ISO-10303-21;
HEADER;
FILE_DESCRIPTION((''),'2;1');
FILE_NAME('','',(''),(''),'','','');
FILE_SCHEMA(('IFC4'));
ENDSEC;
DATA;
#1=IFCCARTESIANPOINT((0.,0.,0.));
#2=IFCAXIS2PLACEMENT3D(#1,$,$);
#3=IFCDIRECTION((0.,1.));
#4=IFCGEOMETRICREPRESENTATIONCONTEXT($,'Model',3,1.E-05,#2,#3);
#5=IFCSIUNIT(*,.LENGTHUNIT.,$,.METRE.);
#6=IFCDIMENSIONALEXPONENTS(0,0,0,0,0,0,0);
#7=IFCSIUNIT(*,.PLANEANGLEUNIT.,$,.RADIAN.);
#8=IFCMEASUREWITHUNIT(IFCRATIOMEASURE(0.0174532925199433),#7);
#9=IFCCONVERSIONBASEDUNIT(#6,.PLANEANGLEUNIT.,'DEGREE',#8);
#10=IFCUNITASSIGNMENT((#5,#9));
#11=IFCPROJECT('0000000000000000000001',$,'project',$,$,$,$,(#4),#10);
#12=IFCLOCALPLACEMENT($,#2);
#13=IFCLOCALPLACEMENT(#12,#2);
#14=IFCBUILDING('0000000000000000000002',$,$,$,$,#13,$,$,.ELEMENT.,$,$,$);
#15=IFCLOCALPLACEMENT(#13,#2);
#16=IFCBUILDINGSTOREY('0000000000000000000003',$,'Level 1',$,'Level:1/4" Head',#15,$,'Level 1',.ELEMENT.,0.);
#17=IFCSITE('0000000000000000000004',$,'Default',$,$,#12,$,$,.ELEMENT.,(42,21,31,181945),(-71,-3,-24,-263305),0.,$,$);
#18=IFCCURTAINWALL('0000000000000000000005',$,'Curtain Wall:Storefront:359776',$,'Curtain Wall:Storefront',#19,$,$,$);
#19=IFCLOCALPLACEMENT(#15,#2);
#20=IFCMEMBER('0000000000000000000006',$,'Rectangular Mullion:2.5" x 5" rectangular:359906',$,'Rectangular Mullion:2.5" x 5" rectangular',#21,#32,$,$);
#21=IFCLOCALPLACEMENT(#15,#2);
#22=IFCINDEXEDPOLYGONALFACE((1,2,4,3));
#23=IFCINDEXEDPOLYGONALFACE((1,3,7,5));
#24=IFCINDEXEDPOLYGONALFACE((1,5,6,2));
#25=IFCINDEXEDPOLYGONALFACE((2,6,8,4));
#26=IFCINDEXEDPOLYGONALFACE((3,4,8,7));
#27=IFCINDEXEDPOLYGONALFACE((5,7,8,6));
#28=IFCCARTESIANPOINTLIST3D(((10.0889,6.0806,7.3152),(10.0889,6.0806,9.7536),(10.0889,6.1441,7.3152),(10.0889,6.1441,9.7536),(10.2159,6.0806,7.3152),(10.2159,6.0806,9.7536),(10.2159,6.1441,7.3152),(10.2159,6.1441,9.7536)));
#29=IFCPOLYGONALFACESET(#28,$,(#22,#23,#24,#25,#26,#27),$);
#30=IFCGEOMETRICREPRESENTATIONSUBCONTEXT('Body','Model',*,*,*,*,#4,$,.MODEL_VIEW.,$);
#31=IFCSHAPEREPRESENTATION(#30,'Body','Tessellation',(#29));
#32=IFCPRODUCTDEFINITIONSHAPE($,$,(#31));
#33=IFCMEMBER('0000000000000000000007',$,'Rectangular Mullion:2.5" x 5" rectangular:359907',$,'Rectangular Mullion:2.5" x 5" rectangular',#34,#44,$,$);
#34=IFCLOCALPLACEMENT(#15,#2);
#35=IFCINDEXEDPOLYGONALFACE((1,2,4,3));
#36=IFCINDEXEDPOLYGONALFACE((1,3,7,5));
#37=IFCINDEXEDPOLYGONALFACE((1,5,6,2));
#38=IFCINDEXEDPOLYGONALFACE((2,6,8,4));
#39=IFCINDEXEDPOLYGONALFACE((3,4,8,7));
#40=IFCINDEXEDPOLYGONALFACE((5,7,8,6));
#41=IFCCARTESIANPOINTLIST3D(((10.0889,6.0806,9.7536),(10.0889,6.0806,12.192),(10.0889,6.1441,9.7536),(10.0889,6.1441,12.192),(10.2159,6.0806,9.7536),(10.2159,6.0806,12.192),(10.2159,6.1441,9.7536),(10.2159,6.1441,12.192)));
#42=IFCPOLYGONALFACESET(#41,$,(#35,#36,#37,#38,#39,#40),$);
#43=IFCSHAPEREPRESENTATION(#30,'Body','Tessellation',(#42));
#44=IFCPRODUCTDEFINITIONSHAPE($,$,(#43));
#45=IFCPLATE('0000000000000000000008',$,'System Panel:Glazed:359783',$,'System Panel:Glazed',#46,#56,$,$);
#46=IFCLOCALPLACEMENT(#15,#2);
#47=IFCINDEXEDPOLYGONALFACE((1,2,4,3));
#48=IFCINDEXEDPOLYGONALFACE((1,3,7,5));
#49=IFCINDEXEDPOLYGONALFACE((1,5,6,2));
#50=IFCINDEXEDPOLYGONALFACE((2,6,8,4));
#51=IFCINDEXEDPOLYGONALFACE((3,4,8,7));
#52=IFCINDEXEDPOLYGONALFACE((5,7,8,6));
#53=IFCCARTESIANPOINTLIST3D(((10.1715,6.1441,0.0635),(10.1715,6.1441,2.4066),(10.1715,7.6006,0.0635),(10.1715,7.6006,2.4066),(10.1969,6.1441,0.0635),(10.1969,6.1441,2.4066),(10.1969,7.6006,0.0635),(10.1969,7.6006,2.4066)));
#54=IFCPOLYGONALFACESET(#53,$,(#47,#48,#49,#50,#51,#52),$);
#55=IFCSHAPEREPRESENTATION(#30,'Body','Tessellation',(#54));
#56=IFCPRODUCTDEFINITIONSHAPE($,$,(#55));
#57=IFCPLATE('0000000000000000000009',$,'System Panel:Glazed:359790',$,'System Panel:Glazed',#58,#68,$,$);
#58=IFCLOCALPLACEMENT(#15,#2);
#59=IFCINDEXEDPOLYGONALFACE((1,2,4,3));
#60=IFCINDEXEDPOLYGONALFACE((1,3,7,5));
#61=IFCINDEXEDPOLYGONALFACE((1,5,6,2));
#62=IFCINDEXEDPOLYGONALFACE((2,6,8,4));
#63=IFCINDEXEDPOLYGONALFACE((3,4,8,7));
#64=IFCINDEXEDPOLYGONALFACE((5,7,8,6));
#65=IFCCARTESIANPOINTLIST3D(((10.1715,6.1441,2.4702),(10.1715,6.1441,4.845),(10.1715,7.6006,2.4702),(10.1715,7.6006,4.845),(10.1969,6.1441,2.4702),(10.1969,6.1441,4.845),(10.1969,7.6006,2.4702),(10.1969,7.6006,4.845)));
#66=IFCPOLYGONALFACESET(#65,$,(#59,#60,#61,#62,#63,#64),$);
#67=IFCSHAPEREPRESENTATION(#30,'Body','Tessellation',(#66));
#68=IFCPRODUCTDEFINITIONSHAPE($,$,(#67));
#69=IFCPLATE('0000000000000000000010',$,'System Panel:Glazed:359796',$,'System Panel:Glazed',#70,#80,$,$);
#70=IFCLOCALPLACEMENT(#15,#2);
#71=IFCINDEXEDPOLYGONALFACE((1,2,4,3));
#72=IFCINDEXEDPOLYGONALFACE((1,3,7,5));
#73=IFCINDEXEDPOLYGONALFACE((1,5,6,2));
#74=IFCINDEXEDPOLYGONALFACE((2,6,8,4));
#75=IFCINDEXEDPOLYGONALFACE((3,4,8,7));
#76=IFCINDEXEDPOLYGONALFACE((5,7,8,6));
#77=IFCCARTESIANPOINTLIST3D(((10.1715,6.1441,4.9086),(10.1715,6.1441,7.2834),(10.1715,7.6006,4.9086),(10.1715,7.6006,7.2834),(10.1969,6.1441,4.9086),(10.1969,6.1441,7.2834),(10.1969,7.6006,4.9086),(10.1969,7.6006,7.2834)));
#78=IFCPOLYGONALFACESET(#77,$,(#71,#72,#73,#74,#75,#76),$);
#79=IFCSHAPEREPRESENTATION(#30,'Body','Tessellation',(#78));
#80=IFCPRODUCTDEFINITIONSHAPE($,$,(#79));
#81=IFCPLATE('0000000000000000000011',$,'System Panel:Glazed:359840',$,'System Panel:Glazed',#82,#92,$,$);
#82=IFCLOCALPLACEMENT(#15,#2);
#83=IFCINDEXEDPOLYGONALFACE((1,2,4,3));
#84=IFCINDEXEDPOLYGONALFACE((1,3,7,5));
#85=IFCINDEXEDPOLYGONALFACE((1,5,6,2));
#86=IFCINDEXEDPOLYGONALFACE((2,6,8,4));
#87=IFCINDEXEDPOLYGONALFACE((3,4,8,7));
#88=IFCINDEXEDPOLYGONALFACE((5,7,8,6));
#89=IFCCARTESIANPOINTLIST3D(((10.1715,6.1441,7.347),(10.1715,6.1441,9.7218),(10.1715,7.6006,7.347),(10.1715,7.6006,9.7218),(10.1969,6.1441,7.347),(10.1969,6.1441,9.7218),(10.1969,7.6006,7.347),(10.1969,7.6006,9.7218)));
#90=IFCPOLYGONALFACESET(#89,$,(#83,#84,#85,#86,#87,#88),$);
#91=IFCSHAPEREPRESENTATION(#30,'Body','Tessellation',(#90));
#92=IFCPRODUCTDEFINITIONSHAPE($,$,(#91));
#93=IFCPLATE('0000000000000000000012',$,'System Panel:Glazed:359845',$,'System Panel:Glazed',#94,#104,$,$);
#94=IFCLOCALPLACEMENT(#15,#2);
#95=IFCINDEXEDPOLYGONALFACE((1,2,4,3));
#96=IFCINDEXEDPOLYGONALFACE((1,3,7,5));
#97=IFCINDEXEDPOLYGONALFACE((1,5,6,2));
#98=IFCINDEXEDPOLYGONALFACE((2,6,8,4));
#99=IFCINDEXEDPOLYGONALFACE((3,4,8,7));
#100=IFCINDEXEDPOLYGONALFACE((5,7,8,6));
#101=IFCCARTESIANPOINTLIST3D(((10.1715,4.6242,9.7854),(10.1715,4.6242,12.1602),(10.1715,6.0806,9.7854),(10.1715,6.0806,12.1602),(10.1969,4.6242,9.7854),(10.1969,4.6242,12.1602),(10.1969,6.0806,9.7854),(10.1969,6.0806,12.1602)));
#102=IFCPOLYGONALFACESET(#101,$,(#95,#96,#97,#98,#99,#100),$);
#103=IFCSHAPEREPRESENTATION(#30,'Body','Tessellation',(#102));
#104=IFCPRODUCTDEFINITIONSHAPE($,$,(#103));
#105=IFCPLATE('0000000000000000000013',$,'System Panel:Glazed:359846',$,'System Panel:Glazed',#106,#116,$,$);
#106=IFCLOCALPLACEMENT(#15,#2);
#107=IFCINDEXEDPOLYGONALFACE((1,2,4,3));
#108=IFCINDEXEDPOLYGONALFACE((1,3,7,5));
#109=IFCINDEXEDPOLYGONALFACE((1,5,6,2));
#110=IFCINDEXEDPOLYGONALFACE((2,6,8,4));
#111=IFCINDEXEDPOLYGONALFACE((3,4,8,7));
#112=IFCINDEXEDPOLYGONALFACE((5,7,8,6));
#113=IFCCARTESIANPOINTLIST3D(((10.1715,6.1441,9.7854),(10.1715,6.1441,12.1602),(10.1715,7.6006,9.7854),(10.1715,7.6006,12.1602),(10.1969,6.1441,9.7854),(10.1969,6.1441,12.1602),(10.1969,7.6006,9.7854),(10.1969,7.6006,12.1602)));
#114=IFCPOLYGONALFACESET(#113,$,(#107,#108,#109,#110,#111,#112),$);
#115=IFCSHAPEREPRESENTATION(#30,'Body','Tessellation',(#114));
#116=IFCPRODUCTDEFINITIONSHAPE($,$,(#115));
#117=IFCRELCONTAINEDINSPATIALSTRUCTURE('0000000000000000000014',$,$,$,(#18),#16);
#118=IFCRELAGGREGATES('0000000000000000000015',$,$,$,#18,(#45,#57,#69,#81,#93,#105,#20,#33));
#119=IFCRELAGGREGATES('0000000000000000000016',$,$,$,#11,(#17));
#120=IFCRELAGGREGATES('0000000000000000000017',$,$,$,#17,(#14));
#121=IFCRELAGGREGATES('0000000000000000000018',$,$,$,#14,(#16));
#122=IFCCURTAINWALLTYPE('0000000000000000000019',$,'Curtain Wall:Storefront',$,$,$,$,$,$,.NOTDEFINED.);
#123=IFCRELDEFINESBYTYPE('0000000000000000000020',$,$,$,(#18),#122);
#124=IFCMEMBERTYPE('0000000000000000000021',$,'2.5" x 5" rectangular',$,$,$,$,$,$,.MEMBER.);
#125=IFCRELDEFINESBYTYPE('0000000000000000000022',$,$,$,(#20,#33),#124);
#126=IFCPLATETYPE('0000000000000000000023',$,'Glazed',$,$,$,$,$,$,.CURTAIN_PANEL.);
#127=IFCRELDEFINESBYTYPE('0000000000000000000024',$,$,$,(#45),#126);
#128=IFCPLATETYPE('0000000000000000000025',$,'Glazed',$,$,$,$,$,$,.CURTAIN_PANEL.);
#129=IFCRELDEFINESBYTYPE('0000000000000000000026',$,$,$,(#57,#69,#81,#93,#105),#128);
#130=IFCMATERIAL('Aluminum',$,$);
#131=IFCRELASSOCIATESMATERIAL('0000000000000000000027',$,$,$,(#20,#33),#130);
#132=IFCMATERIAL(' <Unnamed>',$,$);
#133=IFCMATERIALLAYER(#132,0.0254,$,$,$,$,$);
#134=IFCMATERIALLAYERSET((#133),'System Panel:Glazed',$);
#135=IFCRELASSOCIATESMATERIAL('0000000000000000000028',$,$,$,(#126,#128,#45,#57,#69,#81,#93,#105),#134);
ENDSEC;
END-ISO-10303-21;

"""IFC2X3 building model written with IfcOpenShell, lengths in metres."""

from ifc_helpers import new_model, entity, si_unit, converted_unit, direction, frame, origin, origin_2d_with_axis, place, context, subcontext, project, spatial, rectangle, extrude, source, transform, mapped, material, layer, layer_set, layer_usage, type_object, type_shapes, element, aggregate, save


model = new_model("IFC2X3")

# Units and contexts
model_context = context("Model", 3, precision=1e-05, world=origin(), true_north=direction((0.0, 1.0)))
body_context = subcontext(model_context, "Body", "Model", "MODEL_VIEW")
ifc_project = project(units=[si_unit("LENGTHUNIT", "METRE"), converted_unit("PLANEANGLEUNIT", "DEGREE", entity("IfcRatioMeasure", 0.0174532925199433), si_unit("PLANEANGLEUNIT", "RADIAN"), dimensions=[0, 0, 0, 0, 0, 0, 0])], contexts=[model_context])

# Site, building, storey
site_placement = place(None, origin())
site = spatial("IfcSite", under=ifc_project, at=site_placement, Name="Default", CompositionType="ELEMENT", RefLatitude=(42, 21, 31, 181945), RefLongitude=(-71, -3, -24, -263305), RefElevation=0.0)
building_placement = place(site_placement, origin())
building = spatial("IfcBuilding", under=site, at=building_placement, CompositionType="ELEMENT")
storey_placement = place(building_placement, origin())
storey = spatial("IfcBuildingStorey", under=building, at=storey_placement, Name="Level 1", ObjectType="Level:1/4\" Head", LongName="Level 1", CompositionType="ELEMENT", Elevation=0.0)

# Shared definitions
curtain_wall_type = type_object("IfcCurtainWallType", Name="Curtain Wall:Storefront", PredefinedType="NOTDEFINED")
ifc_material_1 = material(Name="Aluminum")

# Curtain wall, members, plates
curtain_wall_1_placement = place(storey_placement, origin())
curtain_wall_1 = element("IfcCurtainWall", 1, at=curtain_wall_1_placement, inside=storey, type_object=curtain_wall_type, Name="Curtain Wall:Storefront:359776", ObjectType="Curtain Wall:Storefront")
member_type_1 = type_object("IfcMemberType", Name="2.5\" x 5\" rectangular", PredefinedType="MEMBER")
shared_shape_1 = source(origin(), body_context, "Body", "SweptSolid", [
    extrude(rectangle(XDim=0.127, YDim=0.0635, at=origin_2d_with_axis()), frame((0.0, 0.0, -2.4384), z_axis=(0.0, 0.0, 1.0), x_axis=(0.0, -1.0, 0.0)), (0.0, 0.0, 1.0), 2.4384),
])
type_shapes(member_type_1, [shared_shape_1])
member_1_placement = place(storey_placement, frame((10.1524, 6.1124, 7.3152), z_axis=(0.0, 0.0, -1.0), x_axis=(0.0, 1.0, 0.0)))
member_1 = element("IfcMember", 2, at=member_1_placement, type_object=member_type_1, material=ifc_material_1, Name="Rectangular Mullion:2.5\" x 5\" rectangular:359906", ObjectType="Rectangular Mullion:2.5\" x 5\" rectangular", context=body_context, shape_type="MappedRepresentation", body=[
    mapped(shared_shape_1, transform((0.0, 0.0, 0.0), scale=1.0)),
])
member_2_placement = place(storey_placement, frame((10.1524, 6.1124, 9.7536), z_axis=(0.0, 0.0, -1.0), x_axis=(0.0, 1.0, 0.0)))
member_2 = element("IfcMember", 3, at=member_2_placement, type_object=member_type_1, material=ifc_material_1, Name="Rectangular Mullion:2.5\" x 5\" rectangular:359907", ObjectType="Rectangular Mullion:2.5\" x 5\" rectangular", context=body_context, shape_type="MappedRepresentation", body=[
    mapped(shared_shape_1, transform((0.0, 0.0, 0.0), scale=1.0)),
])
ifc_material_2 = material(Name=" <Unnamed>")
ifc_layer = layer(ifc_material_2, 0.0254)
ifc_layer_set = layer_set([ifc_layer], Name="System Panel:Glazed")
ifc_layer_usage_1 = layer_usage(ifc_layer_set, "AXIS3", "POSITIVE", 0.1042)
plate_type_1 = type_object("IfcPlateType", Name="Glazed", PredefinedType="CURTAIN_PANEL", material=ifc_layer_set)
shared_shape_2 = source(origin(), body_context, "Body", "SweptSolid", [
    extrude(rectangle(XDim=0.0254, YDim=1.4565, at=origin_2d_with_axis()), frame((0.7282, 0.0127, 0.0), z_axis=(0.0, 0.0, 1.0), x_axis=(0.0, 1.0, 0.0)), (0.0, 0.0, 1.0), 2.3432),
])
type_shapes(plate_type_1, [shared_shape_2])
plate_1_placement = place(curtain_wall_1_placement, frame((10.1969, 6.1441, 0.0635), z_axis=(0.0, 0.0, 1.0), x_axis=(0.0, 1.0, 0.0)))
plate_1 = element("IfcPlate", 4, at=plate_1_placement, type_object=plate_type_1, material=ifc_layer_usage_1, Name="System Panel:Glazed:359783", ObjectType="System Panel:Glazed", context=body_context, shape_type="MappedRepresentation", body=[
    mapped(shared_shape_2, transform((0.0, 0.0, 0.0), scale=1.0)),
])
ifc_layer_usage_2 = layer_usage(ifc_layer_set, "AXIS3", "POSITIVE", 0.1042)
plate_type_2 = type_object("IfcPlateType", Name="Glazed", PredefinedType="CURTAIN_PANEL", material=ifc_layer_set)
shared_shape_3 = source(origin(), body_context, "Body", "SweptSolid", [
    extrude(rectangle(XDim=0.0254, YDim=1.4565, at=origin_2d_with_axis()), frame((0.7282, 0.0127, 0.0), z_axis=(0.0, 0.0, 1.0), x_axis=(0.0, 1.0, 0.0)), (0.0, 0.0, 1.0), 2.3749),
])
type_shapes(plate_type_2, [shared_shape_3])
plate_2_placement = place(curtain_wall_1_placement, frame((10.1969, 6.1441, 2.4701), z_axis=(0.0, 0.0, 1.0), x_axis=(0.0, 1.0, 0.0)))
plate_2 = element("IfcPlate", 5, at=plate_2_placement, type_object=plate_type_2, material=ifc_layer_usage_2, Name="System Panel:Glazed:359790", ObjectType="System Panel:Glazed", context=body_context, shape_type="MappedRepresentation", body=[
    mapped(shared_shape_3, transform((0.0, 0.0, 0.0), scale=1.0)),
])
ifc_layer_usage_3 = layer_usage(ifc_layer_set, "AXIS3", "POSITIVE", 0.1042)
plate_3_placement = place(curtain_wall_1_placement, frame((10.1969, 6.1441, 4.9085), z_axis=(0.0, 0.0, 1.0), x_axis=(0.0, 1.0, 0.0)))
plate_3 = element("IfcPlate", 6, at=plate_3_placement, type_object=plate_type_2, material=ifc_layer_usage_3, Name="System Panel:Glazed:359796", ObjectType="System Panel:Glazed", context=body_context, shape_type="MappedRepresentation", body=[
    mapped(shared_shape_3, transform((0.0, 0.0, 0.0), scale=1.0)),
])
ifc_layer_usage_4 = layer_usage(ifc_layer_set, "AXIS3", "POSITIVE", 0.1042)
plate_4_placement = place(curtain_wall_1_placement, frame((10.1969, 6.1441, 7.3469), z_axis=(0.0, 0.0, 1.0), x_axis=(0.0, 1.0, 0.0)))
plate_4 = element("IfcPlate", 7, at=plate_4_placement, type_object=plate_type_2, material=ifc_layer_usage_4, Name="System Panel:Glazed:359840", ObjectType="System Panel:Glazed", context=body_context, shape_type="MappedRepresentation", body=[
    mapped(shared_shape_3, transform((0.0, 0.0, 0.0), scale=1.0)),
])
ifc_layer_usage_5 = layer_usage(ifc_layer_set, "AXIS3", "POSITIVE", 0.1042)
plate_5_placement = place(curtain_wall_1_placement, frame((10.1969, 4.6242, 9.7853), z_axis=(0.0, 0.0, 1.0), x_axis=(0.0, 1.0, 0.0)))
plate_5 = element("IfcPlate", 8, at=plate_5_placement, type_object=plate_type_2, material=ifc_layer_usage_5, Name="System Panel:Glazed:359845", ObjectType="System Panel:Glazed", context=body_context, shape_type="MappedRepresentation", body=[
    mapped(shared_shape_3, transform((0.0, 0.0, 0.0), scale=1.0)),
])
ifc_layer_usage_6 = layer_usage(ifc_layer_set, "AXIS3", "POSITIVE", 0.1042)
plate_6_placement = place(curtain_wall_1_placement, frame((10.1969, 6.1441, 9.7853), z_axis=(0.0, 0.0, 1.0), x_axis=(0.0, 1.0, 0.0)))
plate_6 = element("IfcPlate", 9, at=plate_6_placement, type_object=plate_type_2, material=ifc_layer_usage_6, Name="System Panel:Glazed:359846", ObjectType="System Panel:Glazed", context=body_context, shape_type="MappedRepresentation", body=[
    mapped(shared_shape_3, transform((0.0, 0.0, 0.0), scale=1.0)),
])
aggregate(curtain_wall_1, [plate_1, plate_2, plate_3, plate_4, plate_5, plate_6, member_1, member_2])

save(model, "model.ifc")
